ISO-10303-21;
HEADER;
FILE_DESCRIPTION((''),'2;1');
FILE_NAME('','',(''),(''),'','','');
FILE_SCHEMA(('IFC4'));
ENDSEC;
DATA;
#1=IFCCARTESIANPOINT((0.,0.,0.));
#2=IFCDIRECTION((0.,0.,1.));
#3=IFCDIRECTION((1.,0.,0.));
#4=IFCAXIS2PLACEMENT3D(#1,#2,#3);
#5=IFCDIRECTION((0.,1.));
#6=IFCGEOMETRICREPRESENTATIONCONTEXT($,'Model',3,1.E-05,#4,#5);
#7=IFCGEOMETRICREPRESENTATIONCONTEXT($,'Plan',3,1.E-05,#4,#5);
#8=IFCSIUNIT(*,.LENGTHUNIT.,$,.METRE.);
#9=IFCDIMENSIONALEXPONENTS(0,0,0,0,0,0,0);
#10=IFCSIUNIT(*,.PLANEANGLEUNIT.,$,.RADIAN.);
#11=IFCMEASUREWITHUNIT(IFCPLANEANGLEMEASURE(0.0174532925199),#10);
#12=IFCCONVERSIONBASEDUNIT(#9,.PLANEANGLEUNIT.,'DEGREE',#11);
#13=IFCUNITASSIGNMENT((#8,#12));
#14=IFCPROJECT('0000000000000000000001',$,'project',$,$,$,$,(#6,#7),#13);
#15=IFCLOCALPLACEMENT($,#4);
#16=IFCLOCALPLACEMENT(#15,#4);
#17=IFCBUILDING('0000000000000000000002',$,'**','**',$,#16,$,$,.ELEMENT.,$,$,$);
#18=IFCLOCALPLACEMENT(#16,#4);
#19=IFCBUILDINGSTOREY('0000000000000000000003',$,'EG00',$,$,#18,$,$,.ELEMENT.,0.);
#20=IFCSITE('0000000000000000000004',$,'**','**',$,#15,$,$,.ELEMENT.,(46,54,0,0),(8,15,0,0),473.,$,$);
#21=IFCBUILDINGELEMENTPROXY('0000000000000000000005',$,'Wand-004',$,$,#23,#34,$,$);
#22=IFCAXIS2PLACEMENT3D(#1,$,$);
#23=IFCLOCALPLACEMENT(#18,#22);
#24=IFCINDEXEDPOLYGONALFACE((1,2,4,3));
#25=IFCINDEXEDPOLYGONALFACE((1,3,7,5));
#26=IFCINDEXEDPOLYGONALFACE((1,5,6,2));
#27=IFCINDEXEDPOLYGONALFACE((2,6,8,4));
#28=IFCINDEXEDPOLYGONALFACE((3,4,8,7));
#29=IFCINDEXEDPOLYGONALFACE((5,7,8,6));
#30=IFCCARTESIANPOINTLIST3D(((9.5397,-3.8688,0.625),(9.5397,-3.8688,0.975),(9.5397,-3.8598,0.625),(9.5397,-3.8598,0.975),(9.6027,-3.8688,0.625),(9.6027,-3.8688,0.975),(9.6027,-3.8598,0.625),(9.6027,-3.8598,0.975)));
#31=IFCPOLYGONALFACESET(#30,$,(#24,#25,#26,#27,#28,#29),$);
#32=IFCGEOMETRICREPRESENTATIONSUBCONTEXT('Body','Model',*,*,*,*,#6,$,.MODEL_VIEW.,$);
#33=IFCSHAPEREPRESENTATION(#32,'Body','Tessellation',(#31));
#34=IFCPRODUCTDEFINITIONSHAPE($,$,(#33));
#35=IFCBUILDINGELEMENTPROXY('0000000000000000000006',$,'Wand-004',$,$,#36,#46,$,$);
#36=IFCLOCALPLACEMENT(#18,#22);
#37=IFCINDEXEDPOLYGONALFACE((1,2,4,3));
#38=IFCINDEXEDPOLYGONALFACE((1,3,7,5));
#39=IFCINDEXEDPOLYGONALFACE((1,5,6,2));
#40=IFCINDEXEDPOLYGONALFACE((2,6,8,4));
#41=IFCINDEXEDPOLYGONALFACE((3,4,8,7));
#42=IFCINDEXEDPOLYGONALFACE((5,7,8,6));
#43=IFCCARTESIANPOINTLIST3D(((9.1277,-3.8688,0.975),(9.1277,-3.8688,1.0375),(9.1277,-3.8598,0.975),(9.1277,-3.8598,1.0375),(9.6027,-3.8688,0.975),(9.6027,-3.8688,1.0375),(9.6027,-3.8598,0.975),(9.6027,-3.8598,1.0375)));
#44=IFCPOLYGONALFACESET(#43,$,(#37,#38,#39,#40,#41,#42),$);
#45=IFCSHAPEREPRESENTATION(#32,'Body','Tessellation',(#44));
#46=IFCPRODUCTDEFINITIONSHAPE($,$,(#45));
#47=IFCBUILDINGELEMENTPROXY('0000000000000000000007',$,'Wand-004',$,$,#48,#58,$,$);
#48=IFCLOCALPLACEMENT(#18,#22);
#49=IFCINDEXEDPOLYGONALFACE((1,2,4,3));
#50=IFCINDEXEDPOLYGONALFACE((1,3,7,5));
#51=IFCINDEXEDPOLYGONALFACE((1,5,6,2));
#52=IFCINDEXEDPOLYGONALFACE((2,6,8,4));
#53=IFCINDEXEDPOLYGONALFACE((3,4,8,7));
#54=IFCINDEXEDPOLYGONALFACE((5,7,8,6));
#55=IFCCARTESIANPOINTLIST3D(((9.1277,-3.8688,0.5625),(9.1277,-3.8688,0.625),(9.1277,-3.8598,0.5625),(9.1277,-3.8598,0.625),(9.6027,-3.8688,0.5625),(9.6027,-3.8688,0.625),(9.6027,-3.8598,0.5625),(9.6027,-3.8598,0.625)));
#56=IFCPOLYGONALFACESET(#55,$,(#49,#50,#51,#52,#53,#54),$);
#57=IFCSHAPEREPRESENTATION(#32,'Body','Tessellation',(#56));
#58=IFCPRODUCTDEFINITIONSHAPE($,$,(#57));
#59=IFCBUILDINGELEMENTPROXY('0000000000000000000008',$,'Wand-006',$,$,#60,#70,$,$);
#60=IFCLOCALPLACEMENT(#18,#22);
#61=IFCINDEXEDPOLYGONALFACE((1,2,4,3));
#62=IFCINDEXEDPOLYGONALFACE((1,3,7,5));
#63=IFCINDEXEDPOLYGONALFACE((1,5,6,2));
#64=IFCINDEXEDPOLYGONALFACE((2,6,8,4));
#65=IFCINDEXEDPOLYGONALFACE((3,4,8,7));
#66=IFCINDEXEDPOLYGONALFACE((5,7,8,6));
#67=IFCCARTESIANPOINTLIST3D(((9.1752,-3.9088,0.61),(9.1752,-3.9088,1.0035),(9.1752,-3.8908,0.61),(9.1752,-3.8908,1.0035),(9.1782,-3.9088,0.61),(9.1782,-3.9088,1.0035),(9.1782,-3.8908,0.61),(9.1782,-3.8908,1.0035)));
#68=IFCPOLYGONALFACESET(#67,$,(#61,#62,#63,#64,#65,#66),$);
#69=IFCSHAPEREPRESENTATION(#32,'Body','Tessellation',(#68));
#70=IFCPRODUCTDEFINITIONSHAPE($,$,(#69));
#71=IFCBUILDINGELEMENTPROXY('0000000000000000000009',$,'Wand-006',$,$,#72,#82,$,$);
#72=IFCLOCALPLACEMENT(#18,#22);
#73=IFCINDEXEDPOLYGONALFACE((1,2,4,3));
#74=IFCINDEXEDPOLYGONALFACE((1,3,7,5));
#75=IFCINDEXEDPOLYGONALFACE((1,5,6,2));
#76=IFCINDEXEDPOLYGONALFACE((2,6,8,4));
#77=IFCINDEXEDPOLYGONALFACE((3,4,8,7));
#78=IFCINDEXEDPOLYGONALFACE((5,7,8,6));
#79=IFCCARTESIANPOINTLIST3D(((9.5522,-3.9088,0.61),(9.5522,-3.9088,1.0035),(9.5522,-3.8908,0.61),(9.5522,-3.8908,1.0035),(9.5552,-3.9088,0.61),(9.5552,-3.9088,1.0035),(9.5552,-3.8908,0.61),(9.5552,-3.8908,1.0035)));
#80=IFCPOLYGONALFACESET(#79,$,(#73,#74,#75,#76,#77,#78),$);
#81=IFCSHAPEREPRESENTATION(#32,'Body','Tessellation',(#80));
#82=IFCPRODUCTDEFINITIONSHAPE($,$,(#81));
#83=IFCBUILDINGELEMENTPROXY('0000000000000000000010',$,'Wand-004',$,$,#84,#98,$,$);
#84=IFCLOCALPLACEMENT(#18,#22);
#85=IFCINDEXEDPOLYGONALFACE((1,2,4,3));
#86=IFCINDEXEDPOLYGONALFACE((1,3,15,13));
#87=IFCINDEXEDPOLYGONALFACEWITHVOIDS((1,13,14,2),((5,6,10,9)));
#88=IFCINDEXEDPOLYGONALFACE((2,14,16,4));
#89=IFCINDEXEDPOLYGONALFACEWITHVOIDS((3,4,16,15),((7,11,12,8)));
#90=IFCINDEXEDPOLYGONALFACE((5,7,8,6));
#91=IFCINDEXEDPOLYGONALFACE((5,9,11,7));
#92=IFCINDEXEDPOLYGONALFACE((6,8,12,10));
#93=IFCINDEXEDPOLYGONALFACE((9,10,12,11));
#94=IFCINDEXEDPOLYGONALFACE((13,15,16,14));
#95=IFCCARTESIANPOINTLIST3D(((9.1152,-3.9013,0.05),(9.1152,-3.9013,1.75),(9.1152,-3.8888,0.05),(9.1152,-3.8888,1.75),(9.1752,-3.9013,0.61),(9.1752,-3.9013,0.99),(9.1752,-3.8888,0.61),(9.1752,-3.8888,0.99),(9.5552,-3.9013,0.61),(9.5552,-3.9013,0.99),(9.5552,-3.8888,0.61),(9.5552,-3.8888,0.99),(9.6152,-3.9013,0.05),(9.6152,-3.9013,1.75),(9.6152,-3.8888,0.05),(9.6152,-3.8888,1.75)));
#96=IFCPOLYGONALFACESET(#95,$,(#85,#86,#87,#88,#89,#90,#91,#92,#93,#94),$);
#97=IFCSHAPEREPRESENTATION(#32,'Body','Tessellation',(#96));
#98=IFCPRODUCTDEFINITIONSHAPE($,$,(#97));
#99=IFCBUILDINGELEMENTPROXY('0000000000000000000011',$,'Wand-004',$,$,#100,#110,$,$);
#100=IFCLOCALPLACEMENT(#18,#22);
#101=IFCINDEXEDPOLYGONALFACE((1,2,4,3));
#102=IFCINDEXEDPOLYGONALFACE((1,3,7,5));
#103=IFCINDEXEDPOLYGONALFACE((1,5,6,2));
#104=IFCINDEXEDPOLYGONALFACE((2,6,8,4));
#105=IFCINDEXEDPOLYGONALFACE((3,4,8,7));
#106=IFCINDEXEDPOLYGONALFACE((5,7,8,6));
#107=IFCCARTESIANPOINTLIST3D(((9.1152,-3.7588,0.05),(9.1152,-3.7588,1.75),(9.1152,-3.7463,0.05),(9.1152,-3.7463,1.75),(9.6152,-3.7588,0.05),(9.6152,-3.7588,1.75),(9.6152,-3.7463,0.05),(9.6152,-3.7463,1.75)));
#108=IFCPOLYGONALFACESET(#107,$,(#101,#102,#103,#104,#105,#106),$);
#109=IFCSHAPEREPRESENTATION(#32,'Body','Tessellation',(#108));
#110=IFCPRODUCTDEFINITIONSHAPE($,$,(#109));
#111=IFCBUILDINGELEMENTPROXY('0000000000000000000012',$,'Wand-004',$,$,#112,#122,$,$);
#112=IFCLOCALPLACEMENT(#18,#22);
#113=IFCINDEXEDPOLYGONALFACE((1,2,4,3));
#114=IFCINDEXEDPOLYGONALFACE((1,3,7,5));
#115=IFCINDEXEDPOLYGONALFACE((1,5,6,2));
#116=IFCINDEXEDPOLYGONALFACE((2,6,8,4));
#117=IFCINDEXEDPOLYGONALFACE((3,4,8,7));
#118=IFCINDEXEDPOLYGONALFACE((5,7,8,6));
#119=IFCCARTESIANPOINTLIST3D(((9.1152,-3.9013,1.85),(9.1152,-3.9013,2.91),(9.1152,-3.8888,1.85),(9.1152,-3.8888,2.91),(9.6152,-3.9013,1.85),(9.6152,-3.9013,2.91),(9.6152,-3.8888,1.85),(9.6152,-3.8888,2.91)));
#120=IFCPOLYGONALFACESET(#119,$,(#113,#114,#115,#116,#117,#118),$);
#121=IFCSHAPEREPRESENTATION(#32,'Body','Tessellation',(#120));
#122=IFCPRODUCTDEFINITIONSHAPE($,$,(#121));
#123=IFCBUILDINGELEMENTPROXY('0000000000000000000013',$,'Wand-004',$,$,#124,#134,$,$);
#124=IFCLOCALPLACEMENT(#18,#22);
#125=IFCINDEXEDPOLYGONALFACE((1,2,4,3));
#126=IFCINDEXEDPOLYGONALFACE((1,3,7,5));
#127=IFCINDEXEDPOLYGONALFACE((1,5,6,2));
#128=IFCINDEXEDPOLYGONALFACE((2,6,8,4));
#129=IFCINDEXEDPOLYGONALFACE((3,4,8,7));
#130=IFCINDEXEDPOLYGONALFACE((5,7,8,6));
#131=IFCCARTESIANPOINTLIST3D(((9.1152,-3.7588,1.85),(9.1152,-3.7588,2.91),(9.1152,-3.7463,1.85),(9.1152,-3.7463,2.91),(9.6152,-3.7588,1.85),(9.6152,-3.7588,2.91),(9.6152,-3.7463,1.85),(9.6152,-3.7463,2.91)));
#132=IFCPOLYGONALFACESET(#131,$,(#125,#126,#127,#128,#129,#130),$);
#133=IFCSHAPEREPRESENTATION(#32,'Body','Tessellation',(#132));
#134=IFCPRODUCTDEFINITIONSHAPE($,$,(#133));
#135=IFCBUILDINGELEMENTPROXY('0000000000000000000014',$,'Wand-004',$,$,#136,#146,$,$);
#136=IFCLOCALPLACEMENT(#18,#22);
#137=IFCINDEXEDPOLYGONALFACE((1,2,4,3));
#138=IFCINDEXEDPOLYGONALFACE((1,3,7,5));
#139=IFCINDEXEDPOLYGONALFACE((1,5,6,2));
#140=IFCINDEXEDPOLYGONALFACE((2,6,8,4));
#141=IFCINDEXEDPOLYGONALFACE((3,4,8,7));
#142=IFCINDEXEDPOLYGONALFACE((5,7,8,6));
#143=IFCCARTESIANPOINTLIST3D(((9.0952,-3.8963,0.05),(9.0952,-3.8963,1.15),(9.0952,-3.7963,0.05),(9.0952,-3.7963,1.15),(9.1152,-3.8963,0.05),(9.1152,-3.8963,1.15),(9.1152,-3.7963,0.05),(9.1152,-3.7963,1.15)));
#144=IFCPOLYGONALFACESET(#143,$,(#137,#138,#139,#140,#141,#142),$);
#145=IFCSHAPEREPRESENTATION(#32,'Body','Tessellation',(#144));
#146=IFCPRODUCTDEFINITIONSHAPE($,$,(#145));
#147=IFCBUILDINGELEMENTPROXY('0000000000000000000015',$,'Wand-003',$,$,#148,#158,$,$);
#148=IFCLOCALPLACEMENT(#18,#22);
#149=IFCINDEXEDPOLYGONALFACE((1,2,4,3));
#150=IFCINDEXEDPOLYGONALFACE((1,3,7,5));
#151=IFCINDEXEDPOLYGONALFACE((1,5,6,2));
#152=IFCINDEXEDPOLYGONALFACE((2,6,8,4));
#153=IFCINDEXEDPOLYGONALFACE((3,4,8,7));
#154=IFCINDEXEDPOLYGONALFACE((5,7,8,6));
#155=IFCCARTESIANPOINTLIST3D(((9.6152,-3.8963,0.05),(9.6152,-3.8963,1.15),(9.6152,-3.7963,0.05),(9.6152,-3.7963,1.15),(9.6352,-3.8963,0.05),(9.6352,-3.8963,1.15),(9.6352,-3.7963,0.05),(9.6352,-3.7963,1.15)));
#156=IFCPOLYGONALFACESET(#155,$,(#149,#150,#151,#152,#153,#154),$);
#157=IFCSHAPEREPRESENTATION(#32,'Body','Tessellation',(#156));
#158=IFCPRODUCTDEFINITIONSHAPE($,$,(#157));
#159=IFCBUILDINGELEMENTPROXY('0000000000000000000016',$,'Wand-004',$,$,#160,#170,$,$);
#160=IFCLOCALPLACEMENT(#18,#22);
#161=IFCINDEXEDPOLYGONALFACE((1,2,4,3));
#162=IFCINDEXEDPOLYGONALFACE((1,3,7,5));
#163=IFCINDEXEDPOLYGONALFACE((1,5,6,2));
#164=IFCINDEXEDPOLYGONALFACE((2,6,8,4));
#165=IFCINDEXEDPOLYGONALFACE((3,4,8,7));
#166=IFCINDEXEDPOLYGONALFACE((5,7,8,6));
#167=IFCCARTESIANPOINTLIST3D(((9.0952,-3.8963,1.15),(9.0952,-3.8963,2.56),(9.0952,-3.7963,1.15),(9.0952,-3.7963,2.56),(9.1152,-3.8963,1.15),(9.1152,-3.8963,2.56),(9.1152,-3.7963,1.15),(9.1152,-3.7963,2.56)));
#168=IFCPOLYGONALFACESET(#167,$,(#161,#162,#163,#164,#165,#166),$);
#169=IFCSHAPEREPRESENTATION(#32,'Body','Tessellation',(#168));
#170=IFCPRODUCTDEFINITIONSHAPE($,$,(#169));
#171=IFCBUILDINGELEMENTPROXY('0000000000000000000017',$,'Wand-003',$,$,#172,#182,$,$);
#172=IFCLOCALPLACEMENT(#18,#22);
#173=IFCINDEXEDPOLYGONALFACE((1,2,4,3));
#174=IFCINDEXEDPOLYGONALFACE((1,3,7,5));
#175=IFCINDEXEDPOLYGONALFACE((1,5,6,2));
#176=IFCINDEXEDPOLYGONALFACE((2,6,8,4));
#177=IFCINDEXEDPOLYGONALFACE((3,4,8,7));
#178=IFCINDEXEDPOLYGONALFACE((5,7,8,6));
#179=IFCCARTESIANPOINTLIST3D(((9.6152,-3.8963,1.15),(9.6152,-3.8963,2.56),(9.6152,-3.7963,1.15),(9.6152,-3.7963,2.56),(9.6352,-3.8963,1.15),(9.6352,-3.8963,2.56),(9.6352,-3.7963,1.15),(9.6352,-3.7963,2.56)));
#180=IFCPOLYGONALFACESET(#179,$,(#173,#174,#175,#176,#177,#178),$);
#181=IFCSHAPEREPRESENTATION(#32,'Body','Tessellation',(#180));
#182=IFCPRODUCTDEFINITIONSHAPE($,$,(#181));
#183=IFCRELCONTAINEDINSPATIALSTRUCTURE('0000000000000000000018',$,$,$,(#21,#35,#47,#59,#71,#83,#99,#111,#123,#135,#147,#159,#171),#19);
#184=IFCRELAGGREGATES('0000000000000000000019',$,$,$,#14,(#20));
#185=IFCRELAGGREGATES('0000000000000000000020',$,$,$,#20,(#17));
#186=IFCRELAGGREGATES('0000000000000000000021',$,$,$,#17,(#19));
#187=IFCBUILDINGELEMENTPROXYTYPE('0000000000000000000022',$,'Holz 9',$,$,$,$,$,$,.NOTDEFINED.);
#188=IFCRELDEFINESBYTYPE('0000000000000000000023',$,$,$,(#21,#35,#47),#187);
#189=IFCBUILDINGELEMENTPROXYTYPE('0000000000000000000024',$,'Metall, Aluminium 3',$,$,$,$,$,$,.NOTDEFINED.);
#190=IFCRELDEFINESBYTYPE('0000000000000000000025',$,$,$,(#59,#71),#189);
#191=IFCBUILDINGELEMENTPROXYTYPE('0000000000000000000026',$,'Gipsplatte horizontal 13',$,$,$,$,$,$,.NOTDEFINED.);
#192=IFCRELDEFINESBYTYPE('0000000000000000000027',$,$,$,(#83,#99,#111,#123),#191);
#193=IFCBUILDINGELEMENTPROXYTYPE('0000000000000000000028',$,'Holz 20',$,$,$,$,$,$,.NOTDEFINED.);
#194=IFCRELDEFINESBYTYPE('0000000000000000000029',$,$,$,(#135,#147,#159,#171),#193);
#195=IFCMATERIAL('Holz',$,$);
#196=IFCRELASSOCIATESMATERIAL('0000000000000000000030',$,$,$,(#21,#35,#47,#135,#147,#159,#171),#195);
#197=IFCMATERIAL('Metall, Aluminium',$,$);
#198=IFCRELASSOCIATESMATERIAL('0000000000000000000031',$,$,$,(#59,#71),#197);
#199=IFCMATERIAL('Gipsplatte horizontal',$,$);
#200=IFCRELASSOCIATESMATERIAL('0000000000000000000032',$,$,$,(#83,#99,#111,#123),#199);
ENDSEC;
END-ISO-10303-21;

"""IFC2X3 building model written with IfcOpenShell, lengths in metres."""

from ifc_helpers import new_model, entity, si_unit, converted_unit, direction, frame, origin_with_axes, origin_2d_with_axis, place, context, subcontext, project, spatial, polyline, rectangle, outline, extrude, material, type_object, element, save


model = new_model("IFC2X3")

# Units and contexts
model_context = context("Model", 3, precision=1e-05, world=origin_with_axes(), true_north=direction((0.0, 1.0)))
plan_context = context("Plan", 3, precision=1e-05, world=origin_with_axes(), true_north=direction((0.0, 1.0)))
body_context = subcontext(model_context, "Body", "Model", "MODEL_VIEW")
ifc_project = project(units=[si_unit("LENGTHUNIT", "METRE"), converted_unit("PLANEANGLEUNIT", "DEGREE", entity("IfcPlaneAngleMeasure", 0.0174532925199), si_unit("PLANEANGLEUNIT", "RADIAN"), dimensions=[0, 0, 0, 0, 0, 0, 0])], contexts=[model_context, plan_context])

# Site, building, storey
site_placement = place(None, origin_with_axes())
site = spatial("IfcSite", under=ifc_project, at=site_placement, Name="**", Description="**", CompositionType="ELEMENT", RefLatitude=(46, 54, 0, 0), RefLongitude=(8, 15, 0, 0), RefElevation=473.0)
building_placement = place(site_placement, origin_with_axes())
building = spatial("IfcBuilding", under=site, at=building_placement, Name="**", Description="**", CompositionType="ELEMENT")
storey_placement = place(building_placement, origin_with_axes())
storey = spatial("IfcBuildingStorey", under=building, at=storey_placement, Name="EG00", CompositionType="ELEMENT", Elevation=0.0)

# Building element proxies
ifc_material_1 = material(Name="Holz")
building_element_proxy_type_1 = type_object("IfcBuildingElementProxyType", Name="Holz 9", PredefinedType="NOTDEFINED")
for number, where, z_axis, x_axis, name in (
    (1, (9.5397, -3.8688, 0.625), (0.0, 0.0, 1.0), (1.0, 0.0, 0.0), "Wand-004"),
):
    element("IfcBuildingElementProxy", number, at=place(storey_placement, frame(where, z_axis=z_axis, x_axis=x_axis)), inside=storey, type_object=building_element_proxy_type_1, material=ifc_material_1, Name=name, context=body_context, shape_type="SweptSolid", body=[
        extrude(outline(polyline([(0.0, 0.0), (0.063, 0.0), (0.063, 0.009), (0.0, 0.009), (0.0, 0.0)])), origin_with_axes(), (0.0, 0.0, 1.0), 0.35),
    ])
for number, where, z_axis, x_axis, name in (
    (2, (9.6027, -3.8688, 0.975), (0.0, 0.0, 1.0), (-1.0, 0.0, 0.0), "Wand-004"),
    (3, (9.6027, -3.8688, 0.5625), (0.0, 0.0, 1.0), (-1.0, 0.0, 0.0), "Wand-004"),
):
    element("IfcBuildingElementProxy", number, at=place(storey_placement, frame(where, z_axis=z_axis, x_axis=x_axis)), inside=storey, type_object=building_element_proxy_type_1, material=ifc_material_1, Name=name, context=body_context, shape_type="SweptSolid", body=[
        extrude(outline(polyline([(0.0, -0.009), (0.475, -0.009), (0.475, 0.0), (0.0, 0.0), (0.0, -0.009)])), origin_with_axes(), (0.0, 0.0, 1.0), 0.0625),
    ])
ifc_material_2 = material(Name="Metall, Aluminium")
building_element_proxy_type_2 = type_object("IfcBuildingElementProxyType", Name="Metall, Aluminium 3", PredefinedType="NOTDEFINED")
proxy_1_placement = place(storey_placement, frame((9.1752, -3.8908, 0.61), z_axis=(0.0, 0.0, 1.0), x_axis=(0.0, -1.0, 0.0)))
element("IfcBuildingElementProxy", 4, at=proxy_1_placement, inside=storey, type_object=building_element_proxy_type_2, material=ifc_material_2, Name="Wand-006", context=body_context, shape_type="SweptSolid", body=[
    extrude(outline(polyline([(0.0, 0.0), (0.018, 0.0), (0.018, 0.003), (0.0, 0.003), (0.0, 0.0)])), origin_with_axes(), (0.0, 0.0, 1.0), 0.3935),
])
proxy_2_placement = place(storey_placement, frame((9.5552, -3.8908, 0.61), z_axis=(0.0, 0.0, 1.0), x_axis=(0.0, -1.0, 0.0)))
element("IfcBuildingElementProxy", 5, at=proxy_2_placement, inside=storey, type_object=building_element_proxy_type_2, material=ifc_material_2, Name="Wand-006", context=body_context, shape_type="SweptSolid", body=[
    extrude(outline(polyline([(0.0, -0.003), (0.018, -0.003), (0.018, 0.0), (0.0, 0.0), (0.0, -0.003)])), origin_with_axes(), (0.0, 0.0, 1.0), 0.3935),
])

# Building element proxy, opening
ifc_material_3 = material(Name="Gipsplatte horizontal")
building_element_proxy_type_3 = type_object("IfcBuildingElementProxyType", Name="Gipsplatte horizontal 13", PredefinedType="NOTDEFINED")
proxy_3_placement = place(storey_placement, frame((9.1152, -3.9013, 0.05), z_axis=(0.0, 0.0, 1.0), x_axis=(1.0, 0.0, 0.0)))
proxy_3 = element("IfcBuildingElementProxy", 6, at=proxy_3_placement, inside=storey, type_object=building_element_proxy_type_3, material=ifc_material_3, Name="Wand-004", context=body_context, shape_type="SweptSolid", body=[
    extrude(outline(polyline([(0.0, 0.0), (0.5, 0.0), (0.5, 0.0125), (0.0, 0.0125), (0.0, 0.0)])), origin_with_axes(), (0.0, 0.0, 1.0), 1.7),
])
opening_placement = place(proxy_3_placement, frame((-9.1152, 3.9013, -0.05), z_axis=(0.0, 0.0, 1.0), x_axis=(1.0, 0.0, 0.0)))
element("IfcOpeningElement", 7, at=opening_placement, cuts=proxy_3, context=body_context, shape_type="SweptSolid", body=[
    extrude(rectangle(XDim=0.38, YDim=0.38, at=origin_2d_with_axis()), frame((9.3652, -3.9138, 0.8), z_axis=(0.0, -1.0, 0.0), x_axis=(1.0, 0.0, 0.0)), (0.0, 0.0, -1.0), 0.0375),
])

# Building element proxies
proxy_4_placement = place(storey_placement, frame((9.1152, -3.7463, 0.05), z_axis=(0.0, 0.0, 1.0), x_axis=(1.0, 0.0, 0.0)))
element("IfcBuildingElementProxy", 8, at=proxy_4_placement, inside=storey, type_object=building_element_proxy_type_3, material=ifc_material_3, Name="Wand-004", context=body_context, shape_type="SweptSolid", body=[
    extrude(outline(polyline([(0.0, -0.0125), (0.5, -0.0125), (0.5, 0.0), (0.0, 0.0), (0.0, -0.0125)])), origin_with_axes(), (0.0, 0.0, 1.0), 1.7),
])
proxy_5_placement = place(storey_placement, frame((9.1152, -3.9013, 1.85), z_axis=(0.0, 0.0, 1.0), x_axis=(1.0, 0.0, 0.0)))
element("IfcBuildingElementProxy", 9, at=proxy_5_placement, inside=storey, type_object=building_element_proxy_type_3, material=ifc_material_3, Name="Wand-004", context=body_context, shape_type="SweptSolid", body=[
    extrude(outline(polyline([(0.0, 0.0), (0.5, 0.0), (0.5, 0.0125), (0.0, 0.0125), (0.0, 0.0)])), origin_with_axes(), (0.0, 0.0, 1.0), 1.06),
])
proxy_6_placement = place(storey_placement, frame((9.1152, -3.7463, 1.85), z_axis=(0.0, 0.0, 1.0), x_axis=(1.0, 0.0, 0.0)))
element("IfcBuildingElementProxy", 10, at=proxy_6_placement, inside=storey, type_object=building_element_proxy_type_3, material=ifc_material_3, Name="Wand-004", context=body_context, shape_type="SweptSolid", body=[
    extrude(outline(polyline([(0.0, -0.0125), (0.5, -0.0125), (0.5, 0.0), (0.0, 0.0), (0.0, -0.0125)])), origin_with_axes(), (0.0, 0.0, 1.0), 1.06),
])
building_element_proxy_type_4 = type_object("IfcBuildingElementProxyType", Name="Holz 20", PredefinedType="NOTDEFINED")
proxy_7_placement = place(storey_placement, frame((9.0952, -3.7963, 0.05), z_axis=(0.0, 0.0, 1.0), x_axis=(0.0, -1.0, 0.0)))
element("IfcBuildingElementProxy", 11, at=proxy_7_placement, inside=storey, type_object=building_element_proxy_type_4, material=ifc_material_1, Name="Wand-004", context=body_context, shape_type="SweptSolid", body=[
    extrude(outline(polyline([(0.0, 0.0), (0.1, 0.0), (0.1, 0.02), (0.0, 0.02), (0.0, 0.0)])), origin_with_axes(), (0.0, 0.0, 1.0), 1.1),
])
proxy_8_placement = place(storey_placement, frame((9.6352, -3.7963, 0.05), z_axis=(0.0, 0.0, 1.0), x_axis=(0.0, -1.0, 0.0)))
element("IfcBuildingElementProxy", 12, at=proxy_8_placement, inside=storey, type_object=building_element_proxy_type_4, material=ifc_material_1, Name="Wand-003", context=body_context, shape_type="SweptSolid", body=[
    extrude(outline(polyline([(0.0, -0.02), (0.1, -0.02), (0.1, 0.0), (0.0, 0.0), (0.0, -0.02)])), origin_with_axes(), (0.0, 0.0, 1.0), 1.1),
])
proxy_9_placement = place(storey_placement, frame((9.0952, -3.7963, 1.15), z_axis=(0.0, 0.0, 1.0), x_axis=(0.0, -1.0, 0.0)))
element("IfcBuildingElementProxy", 13, at=proxy_9_placement, inside=storey, type_object=building_element_proxy_type_4, material=ifc_material_1, Name="Wand-004", context=body_context, shape_type="SweptSolid", body=[
    extrude(outline(polyline([(0.0, 0.0), (0.1, 0.0), (0.1, 0.02), (0.0, 0.02), (0.0, 0.0)])), origin_with_axes(), (0.0, 0.0, 1.0), 1.41),
])
proxy_10_placement = place(storey_placement, frame((9.6352, -3.7963, 1.15), z_axis=(0.0, 0.0, 1.0), x_axis=(0.0, -1.0, 0.0)))
element("IfcBuildingElementProxy", 14, at=proxy_10_placement, inside=storey, type_object=building_element_proxy_type_4, material=ifc_material_1, Name="Wand-003", context=body_context, shape_type="SweptSolid", body=[
    extrude(outline(polyline([(0.0, -0.02), (0.1, -0.02), (0.1, 0.0), (0.0, 0.0), (0.0, -0.02)])), origin_with_axes(), (0.0, 0.0, 1.0), 1.41),
])

save(model, "model.ifc")
